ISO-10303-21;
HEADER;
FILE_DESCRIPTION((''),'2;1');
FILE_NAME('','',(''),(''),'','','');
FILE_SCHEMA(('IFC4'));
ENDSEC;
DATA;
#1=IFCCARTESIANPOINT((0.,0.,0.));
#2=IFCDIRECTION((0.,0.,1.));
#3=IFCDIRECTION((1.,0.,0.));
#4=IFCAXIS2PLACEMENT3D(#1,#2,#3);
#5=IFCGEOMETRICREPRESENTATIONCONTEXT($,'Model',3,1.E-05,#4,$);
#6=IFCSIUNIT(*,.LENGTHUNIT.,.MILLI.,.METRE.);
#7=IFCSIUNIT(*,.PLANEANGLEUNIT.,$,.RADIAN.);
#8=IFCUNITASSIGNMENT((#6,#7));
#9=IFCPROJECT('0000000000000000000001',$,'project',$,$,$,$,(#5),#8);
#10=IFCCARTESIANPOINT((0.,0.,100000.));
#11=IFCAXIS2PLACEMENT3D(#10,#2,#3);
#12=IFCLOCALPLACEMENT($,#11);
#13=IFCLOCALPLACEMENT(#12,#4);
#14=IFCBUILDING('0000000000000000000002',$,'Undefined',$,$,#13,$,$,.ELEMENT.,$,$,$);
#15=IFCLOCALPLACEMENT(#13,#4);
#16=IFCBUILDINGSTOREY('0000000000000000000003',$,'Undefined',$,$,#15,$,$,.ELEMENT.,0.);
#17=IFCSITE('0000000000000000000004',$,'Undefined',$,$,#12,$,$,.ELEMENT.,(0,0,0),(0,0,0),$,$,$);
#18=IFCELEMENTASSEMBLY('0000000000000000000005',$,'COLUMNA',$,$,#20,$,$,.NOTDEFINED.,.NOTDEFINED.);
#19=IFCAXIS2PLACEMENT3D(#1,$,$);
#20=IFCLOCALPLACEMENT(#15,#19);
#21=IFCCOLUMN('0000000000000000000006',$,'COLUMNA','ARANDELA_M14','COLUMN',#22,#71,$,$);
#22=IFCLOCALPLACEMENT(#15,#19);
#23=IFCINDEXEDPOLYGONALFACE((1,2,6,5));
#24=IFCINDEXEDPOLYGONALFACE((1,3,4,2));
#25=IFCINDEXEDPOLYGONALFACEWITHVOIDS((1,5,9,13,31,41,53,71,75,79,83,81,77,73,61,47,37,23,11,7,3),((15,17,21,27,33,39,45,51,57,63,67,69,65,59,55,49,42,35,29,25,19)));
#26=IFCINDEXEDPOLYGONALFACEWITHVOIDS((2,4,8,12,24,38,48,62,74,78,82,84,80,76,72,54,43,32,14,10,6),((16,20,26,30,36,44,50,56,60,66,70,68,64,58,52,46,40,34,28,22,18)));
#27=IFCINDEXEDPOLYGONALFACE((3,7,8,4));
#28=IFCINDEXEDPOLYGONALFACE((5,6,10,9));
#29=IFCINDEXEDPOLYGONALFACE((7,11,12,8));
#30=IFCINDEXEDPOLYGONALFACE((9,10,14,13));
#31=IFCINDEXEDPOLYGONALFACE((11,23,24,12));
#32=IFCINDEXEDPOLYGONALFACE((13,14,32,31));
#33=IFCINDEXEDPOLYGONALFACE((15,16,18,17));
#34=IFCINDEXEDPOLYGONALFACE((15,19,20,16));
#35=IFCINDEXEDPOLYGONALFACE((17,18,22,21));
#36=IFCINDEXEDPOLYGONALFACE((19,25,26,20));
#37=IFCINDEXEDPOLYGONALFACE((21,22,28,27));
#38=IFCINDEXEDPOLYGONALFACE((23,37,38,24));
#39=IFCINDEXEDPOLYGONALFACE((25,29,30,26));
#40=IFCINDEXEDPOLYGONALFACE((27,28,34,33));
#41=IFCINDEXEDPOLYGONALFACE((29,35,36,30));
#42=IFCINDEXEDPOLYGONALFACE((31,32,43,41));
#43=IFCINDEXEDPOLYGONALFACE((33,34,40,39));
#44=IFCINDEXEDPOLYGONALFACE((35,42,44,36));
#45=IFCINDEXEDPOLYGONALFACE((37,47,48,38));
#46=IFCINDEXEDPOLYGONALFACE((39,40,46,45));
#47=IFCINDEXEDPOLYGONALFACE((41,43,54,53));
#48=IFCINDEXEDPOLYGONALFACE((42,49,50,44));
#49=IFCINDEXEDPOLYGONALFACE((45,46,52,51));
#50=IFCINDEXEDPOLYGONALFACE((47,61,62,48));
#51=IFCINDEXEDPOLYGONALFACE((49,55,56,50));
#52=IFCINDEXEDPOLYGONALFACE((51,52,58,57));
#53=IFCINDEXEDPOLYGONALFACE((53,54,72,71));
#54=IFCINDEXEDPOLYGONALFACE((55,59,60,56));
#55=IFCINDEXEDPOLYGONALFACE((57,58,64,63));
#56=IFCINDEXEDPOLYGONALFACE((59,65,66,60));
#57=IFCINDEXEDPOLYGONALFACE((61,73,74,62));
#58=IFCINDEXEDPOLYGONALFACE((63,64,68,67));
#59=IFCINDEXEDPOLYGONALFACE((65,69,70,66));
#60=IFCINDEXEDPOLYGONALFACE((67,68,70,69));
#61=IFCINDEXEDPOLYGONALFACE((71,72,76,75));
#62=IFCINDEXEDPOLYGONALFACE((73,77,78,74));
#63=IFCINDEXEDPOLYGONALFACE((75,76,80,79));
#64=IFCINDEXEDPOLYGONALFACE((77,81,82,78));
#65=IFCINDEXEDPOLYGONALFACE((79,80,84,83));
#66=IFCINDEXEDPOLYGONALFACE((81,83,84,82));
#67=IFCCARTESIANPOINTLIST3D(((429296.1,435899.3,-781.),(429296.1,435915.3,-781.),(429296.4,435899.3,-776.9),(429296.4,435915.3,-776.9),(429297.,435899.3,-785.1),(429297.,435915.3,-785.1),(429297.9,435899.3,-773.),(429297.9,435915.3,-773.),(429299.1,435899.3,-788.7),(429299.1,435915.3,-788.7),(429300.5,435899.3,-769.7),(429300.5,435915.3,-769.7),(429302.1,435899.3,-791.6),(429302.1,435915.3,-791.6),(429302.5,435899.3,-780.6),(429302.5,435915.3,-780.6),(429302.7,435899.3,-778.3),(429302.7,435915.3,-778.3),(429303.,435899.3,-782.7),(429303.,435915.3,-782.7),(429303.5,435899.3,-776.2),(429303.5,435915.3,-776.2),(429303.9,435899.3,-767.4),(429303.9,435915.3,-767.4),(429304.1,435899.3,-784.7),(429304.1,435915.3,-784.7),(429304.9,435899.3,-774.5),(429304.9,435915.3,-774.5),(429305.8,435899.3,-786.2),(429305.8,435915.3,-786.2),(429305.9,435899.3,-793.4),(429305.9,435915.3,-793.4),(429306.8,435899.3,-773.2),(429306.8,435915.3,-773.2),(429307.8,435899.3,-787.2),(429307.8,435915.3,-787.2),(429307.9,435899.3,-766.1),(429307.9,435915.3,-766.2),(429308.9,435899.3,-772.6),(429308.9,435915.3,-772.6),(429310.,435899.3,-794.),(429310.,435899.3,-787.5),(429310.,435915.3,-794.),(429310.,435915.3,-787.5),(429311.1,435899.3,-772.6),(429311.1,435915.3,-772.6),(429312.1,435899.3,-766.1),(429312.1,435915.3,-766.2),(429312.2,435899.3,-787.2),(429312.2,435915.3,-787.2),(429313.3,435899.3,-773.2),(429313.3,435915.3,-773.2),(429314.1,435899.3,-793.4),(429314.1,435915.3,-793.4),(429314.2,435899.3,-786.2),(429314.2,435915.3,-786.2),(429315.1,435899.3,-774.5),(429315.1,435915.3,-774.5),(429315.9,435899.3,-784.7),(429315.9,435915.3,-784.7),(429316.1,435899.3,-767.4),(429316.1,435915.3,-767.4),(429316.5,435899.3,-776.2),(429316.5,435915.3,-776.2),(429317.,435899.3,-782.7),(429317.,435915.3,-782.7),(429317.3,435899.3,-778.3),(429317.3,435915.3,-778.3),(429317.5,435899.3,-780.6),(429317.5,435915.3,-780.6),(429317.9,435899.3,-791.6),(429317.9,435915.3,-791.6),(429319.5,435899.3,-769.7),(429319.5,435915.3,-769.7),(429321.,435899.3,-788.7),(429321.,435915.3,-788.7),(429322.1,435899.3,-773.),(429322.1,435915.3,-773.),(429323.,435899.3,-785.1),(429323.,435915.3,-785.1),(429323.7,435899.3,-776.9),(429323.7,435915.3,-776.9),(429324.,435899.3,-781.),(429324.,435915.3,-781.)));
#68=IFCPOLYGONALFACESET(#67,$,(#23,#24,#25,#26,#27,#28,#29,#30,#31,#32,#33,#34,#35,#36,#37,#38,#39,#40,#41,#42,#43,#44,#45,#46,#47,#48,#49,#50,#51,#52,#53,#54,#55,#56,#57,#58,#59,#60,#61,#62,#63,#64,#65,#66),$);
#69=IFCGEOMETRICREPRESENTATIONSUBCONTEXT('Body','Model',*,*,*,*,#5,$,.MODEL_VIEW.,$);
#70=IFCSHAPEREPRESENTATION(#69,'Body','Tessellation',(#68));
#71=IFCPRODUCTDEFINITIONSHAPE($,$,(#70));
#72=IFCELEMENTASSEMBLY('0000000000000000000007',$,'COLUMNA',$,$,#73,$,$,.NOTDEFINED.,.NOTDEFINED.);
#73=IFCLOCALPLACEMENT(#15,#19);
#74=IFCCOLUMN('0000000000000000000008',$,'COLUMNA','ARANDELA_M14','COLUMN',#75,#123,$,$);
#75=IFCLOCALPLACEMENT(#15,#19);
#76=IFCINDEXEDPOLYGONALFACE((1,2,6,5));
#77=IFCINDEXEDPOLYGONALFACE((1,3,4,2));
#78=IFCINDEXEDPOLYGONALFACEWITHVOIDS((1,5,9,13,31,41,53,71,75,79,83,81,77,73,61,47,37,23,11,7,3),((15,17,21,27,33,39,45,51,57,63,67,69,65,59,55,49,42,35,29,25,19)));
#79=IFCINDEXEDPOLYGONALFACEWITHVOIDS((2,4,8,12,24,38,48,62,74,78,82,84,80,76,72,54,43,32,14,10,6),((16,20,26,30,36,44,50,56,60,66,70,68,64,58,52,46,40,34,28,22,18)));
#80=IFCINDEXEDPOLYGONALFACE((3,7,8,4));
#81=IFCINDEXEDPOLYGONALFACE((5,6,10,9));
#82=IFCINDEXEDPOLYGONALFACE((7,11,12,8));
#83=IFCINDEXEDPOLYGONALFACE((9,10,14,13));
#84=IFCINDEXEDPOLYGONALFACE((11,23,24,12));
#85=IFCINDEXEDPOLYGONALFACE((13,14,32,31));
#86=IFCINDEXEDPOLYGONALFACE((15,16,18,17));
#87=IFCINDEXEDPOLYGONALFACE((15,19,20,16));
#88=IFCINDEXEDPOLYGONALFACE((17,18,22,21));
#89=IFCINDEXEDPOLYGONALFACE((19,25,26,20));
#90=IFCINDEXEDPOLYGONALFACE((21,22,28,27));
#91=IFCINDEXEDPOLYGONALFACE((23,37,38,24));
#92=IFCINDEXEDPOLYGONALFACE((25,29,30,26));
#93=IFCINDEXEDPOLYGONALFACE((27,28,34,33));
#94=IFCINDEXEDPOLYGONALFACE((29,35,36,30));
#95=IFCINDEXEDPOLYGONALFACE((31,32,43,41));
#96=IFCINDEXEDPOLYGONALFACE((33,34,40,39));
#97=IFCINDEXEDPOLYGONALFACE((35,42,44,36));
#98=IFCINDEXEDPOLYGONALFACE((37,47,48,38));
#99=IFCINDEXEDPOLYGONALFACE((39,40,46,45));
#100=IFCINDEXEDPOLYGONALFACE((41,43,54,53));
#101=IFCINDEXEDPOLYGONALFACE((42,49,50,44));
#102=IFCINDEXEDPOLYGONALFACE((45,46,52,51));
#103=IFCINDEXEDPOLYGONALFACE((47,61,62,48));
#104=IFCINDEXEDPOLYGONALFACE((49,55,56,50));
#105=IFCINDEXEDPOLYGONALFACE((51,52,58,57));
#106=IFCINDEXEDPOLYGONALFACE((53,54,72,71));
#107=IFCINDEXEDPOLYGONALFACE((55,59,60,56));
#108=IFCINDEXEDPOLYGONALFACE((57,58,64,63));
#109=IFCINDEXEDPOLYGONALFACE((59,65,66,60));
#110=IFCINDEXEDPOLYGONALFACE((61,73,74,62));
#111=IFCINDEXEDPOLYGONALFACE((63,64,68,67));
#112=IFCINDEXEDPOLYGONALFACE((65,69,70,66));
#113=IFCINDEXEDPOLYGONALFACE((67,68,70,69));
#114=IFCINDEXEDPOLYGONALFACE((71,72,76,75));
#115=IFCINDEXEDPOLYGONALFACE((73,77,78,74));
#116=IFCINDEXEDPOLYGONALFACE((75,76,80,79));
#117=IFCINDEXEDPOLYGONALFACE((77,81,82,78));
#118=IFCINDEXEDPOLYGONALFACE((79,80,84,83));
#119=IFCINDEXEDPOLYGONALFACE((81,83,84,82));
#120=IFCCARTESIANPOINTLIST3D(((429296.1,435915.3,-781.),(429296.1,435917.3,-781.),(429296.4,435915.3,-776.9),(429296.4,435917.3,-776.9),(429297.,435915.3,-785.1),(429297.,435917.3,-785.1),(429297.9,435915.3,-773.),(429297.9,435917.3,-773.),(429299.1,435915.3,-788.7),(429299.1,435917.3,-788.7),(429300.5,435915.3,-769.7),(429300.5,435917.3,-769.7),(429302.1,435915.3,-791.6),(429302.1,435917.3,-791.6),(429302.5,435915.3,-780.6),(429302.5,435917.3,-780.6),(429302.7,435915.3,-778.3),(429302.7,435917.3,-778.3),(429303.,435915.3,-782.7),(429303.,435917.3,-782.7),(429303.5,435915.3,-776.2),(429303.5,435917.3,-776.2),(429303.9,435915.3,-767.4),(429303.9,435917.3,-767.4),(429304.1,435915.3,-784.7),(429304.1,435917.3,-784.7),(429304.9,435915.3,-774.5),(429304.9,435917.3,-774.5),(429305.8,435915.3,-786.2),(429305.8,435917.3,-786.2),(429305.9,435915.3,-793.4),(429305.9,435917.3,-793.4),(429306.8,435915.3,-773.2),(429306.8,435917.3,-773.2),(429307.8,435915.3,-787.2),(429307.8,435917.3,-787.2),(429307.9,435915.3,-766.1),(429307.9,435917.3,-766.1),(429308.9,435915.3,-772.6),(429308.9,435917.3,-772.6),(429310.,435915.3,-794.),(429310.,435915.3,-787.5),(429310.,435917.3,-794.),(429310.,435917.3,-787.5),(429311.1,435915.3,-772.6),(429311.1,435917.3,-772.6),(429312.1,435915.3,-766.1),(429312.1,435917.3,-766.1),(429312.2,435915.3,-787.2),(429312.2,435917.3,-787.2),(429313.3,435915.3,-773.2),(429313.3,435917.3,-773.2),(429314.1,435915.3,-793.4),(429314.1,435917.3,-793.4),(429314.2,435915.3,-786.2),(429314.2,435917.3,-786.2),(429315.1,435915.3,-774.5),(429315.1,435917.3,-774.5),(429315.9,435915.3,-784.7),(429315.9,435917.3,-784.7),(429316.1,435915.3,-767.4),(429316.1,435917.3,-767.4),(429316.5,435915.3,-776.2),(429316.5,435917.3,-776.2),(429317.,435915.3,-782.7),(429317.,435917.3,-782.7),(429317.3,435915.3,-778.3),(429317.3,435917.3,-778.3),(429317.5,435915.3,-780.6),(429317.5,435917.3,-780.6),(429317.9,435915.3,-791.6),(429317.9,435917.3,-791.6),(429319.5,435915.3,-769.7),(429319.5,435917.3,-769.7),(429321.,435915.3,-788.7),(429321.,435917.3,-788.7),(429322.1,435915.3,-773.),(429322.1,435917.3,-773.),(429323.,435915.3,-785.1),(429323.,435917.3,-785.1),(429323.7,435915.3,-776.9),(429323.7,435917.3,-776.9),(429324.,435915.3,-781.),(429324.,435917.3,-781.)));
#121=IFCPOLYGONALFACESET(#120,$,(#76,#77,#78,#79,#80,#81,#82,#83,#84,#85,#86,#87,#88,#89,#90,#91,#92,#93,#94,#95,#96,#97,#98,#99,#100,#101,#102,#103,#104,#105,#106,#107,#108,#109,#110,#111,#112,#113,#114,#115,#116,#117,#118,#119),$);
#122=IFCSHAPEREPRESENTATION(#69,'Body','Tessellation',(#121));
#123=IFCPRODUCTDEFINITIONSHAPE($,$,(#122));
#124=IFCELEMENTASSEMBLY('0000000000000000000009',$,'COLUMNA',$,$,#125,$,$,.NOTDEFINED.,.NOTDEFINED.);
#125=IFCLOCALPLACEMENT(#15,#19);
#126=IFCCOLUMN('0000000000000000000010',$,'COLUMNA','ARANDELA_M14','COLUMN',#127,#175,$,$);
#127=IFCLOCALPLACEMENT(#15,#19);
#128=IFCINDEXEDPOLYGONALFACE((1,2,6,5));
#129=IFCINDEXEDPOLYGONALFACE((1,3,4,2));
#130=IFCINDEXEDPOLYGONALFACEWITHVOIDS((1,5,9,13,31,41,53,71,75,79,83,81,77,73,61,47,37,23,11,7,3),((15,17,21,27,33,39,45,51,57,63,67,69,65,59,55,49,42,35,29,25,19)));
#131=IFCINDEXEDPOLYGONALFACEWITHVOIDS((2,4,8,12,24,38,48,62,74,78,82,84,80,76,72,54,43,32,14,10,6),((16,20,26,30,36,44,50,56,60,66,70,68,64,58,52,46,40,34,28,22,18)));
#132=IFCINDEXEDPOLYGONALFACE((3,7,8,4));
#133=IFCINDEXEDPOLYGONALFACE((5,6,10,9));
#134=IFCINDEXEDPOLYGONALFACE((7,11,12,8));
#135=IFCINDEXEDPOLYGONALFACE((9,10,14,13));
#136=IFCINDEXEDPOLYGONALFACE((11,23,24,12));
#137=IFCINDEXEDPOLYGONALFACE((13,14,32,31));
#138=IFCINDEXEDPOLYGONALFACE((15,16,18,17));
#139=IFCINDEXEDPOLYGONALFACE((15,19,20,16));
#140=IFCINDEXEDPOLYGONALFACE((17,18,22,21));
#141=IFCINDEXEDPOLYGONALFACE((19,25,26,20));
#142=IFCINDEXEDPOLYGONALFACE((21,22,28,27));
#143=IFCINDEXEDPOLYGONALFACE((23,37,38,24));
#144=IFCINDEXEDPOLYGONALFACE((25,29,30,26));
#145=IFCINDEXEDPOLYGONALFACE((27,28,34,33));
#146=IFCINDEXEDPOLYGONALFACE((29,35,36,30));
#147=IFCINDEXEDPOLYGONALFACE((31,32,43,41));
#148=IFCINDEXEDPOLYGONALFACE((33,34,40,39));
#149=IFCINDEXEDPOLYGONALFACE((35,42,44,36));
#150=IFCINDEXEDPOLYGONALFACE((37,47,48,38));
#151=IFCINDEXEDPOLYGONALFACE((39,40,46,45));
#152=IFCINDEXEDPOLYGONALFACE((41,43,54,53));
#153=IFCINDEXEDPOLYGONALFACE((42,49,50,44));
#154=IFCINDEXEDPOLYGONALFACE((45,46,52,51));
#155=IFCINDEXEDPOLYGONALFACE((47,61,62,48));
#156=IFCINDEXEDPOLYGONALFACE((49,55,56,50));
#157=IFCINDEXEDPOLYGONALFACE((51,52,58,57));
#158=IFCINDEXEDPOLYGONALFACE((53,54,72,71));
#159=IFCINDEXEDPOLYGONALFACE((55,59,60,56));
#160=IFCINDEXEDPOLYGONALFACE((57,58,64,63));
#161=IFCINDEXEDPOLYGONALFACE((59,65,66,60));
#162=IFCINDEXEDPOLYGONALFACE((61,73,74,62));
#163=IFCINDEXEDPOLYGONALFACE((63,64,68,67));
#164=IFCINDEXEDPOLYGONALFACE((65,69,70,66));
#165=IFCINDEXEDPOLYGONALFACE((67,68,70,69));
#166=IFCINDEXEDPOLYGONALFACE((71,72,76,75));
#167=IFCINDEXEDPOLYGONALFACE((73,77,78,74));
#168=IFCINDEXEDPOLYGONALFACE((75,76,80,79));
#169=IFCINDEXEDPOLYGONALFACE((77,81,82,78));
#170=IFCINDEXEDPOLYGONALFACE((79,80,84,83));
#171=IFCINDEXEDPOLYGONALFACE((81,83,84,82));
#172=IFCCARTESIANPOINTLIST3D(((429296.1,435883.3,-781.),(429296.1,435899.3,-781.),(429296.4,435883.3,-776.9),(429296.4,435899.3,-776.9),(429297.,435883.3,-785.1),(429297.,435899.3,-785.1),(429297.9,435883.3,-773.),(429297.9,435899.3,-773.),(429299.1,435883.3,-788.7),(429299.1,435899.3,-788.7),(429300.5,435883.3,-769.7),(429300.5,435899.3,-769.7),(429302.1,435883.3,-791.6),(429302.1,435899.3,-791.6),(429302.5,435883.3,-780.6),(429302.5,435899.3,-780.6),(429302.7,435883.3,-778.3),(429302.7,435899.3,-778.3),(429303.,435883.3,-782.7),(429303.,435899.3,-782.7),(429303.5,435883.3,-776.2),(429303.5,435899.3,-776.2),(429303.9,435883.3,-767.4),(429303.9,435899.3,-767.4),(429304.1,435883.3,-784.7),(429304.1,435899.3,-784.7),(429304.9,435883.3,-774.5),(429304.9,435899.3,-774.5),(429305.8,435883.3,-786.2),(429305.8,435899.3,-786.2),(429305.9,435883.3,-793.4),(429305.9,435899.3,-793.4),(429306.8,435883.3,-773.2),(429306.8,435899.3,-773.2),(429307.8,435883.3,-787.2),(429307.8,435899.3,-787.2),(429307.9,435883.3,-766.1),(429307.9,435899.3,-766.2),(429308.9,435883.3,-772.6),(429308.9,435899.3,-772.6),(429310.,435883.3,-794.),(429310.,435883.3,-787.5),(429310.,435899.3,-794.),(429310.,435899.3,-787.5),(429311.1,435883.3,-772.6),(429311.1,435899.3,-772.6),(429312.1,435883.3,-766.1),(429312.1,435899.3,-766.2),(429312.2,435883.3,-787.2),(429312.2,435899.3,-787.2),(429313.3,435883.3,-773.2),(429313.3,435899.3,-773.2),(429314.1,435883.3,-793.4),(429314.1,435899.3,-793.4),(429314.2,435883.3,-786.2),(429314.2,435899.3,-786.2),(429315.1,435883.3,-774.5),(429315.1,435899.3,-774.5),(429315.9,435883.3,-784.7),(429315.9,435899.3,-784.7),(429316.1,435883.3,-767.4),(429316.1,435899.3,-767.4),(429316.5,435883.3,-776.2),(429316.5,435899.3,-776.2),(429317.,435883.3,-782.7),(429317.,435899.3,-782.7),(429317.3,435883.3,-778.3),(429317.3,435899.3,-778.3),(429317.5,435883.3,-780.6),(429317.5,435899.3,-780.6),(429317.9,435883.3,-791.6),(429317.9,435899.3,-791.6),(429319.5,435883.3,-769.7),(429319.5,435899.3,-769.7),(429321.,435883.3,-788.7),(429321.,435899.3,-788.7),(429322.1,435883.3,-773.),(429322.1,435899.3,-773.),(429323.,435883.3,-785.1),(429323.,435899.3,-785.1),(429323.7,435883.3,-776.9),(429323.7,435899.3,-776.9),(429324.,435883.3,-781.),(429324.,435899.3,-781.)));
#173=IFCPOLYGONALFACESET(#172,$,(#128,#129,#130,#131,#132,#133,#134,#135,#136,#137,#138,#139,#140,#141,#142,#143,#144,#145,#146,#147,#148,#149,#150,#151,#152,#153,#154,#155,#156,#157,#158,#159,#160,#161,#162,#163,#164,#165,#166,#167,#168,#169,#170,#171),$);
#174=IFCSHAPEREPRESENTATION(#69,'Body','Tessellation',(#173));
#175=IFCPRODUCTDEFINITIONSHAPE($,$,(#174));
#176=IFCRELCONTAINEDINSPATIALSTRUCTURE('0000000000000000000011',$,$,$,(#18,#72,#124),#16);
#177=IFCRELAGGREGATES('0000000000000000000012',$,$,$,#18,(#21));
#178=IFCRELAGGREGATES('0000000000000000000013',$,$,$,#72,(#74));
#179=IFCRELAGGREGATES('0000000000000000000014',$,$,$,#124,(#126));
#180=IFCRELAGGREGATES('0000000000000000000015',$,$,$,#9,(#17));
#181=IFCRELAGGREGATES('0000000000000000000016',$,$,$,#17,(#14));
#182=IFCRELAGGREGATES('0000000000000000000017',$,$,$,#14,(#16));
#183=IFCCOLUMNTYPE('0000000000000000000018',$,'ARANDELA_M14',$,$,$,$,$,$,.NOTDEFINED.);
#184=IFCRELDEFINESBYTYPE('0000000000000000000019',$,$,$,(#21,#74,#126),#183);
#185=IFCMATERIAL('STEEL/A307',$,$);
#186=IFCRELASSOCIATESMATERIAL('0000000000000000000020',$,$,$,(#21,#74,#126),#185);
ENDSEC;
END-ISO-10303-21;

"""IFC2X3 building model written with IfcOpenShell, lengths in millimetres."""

from ifc_helpers import new_model, si_unit, frame, origin_with_axes, origin_2d_with_axis, place, context, subcontext, project, spatial, hollow_circle, extrude, material, type_object, element, aggregate, save


model = new_model("IFC2X3")

# Units and contexts
model_context = context("Model", 3, precision=1e-05, world=origin_with_axes())
body_context = subcontext(model_context, "Body", "Model", "MODEL_VIEW")
ifc_project = project(units=[si_unit("LENGTHUNIT", "METRE", prefix="MILLI"), si_unit("PLANEANGLEUNIT", "RADIAN")], contexts=[model_context])

# Site, building, storey
site_placement = place(None, frame((0.0, 0.0, 100000.0), z_axis=(0.0, 0.0, 1.0), x_axis=(1.0, 0.0, 0.0)))
site = spatial("IfcSite", under=ifc_project, at=site_placement, Name="Undefined", CompositionType="ELEMENT", RefLatitude=(0, 0, 0), RefLongitude=(0, 0, 0))
building_placement = place(site_placement, origin_with_axes())
building = spatial("IfcBuilding", under=site, at=building_placement, Name="Undefined", CompositionType="ELEMENT")
storey_placement = place(building_placement, origin_with_axes())
storey = spatial("IfcBuildingStorey", under=building, at=storey_placement, Name="Undefined", CompositionType="ELEMENT", Elevation=0.0)

# Element assemblies, columns
ifc_material_1 = material(Name="STEEL/A307")
column_type = type_object("IfcColumnType", Name="ARANDELA_M14", PredefinedType="NOTDEFINED")
assembly_1_placement = place(storey_placement, origin_with_axes())
assembly_1 = element("IfcElementAssembly", 1, at=assembly_1_placement, inside=storey, Name="COLUMNA", AssemblyPlace="NOTDEFINED", PredefinedType="NOTDEFINED")
column_1_placement = place(assembly_1_placement, frame((429310.0, 435915.3, -780.0), z_axis=(0.0, -1.0, 0.000285), x_axis=(-1.0, 0.0, 0.0)))
column_1 = element("IfcColumn", 2, at=column_1_placement, type_object=column_type, material=ifc_material_1, Name="COLUMNA", Description="ARANDELA_M14", ObjectType="COLUMN", context=body_context, shape_type="SweptSolid", body=[
    extrude(hollow_circle(Radius=14.0, WallThickness=6.5, at=origin_2d_with_axis()), frame((0.0, 0.0, 16.0), z_axis=(0.0, 0.0, -1.0), x_axis=(0.0, 1.0, 0.0)), (0.0, 0.0, 1.0), 16.0),
])
aggregate(assembly_1, [column_1])
assembly_2_placement = place(storey_placement, origin_with_axes())
assembly_2 = element("IfcElementAssembly", 3, at=assembly_2_placement, inside=storey, Name="COLUMNA", AssemblyPlace="NOTDEFINED", PredefinedType="NOTDEFINED")
column_2_placement = place(assembly_2_placement, frame((429310.0, 435917.3, -780.0), z_axis=(0.0, -1.0, 0.000285), x_axis=(-1.0, 0.0, 0.0)))
column_2 = element("IfcColumn", 4, at=column_2_placement, type_object=column_type, material=ifc_material_1, Name="COLUMNA", Description="ARANDELA_M14", ObjectType="COLUMN", context=body_context, shape_type="SweptSolid", body=[
    extrude(hollow_circle(Radius=14.0, WallThickness=6.5, at=origin_2d_with_axis()), frame((0.0, 0.0, 2.0), z_axis=(0.0, 0.0, -1.0), x_axis=(0.0, 1.0, 0.0)), (0.0, 0.0, 1.0), 2.0),
])
aggregate(assembly_2, [column_2])
assembly_3_placement = place(storey_placement, origin_with_axes())
assembly_3 = element("IfcElementAssembly", 5, at=assembly_3_placement, inside=storey, Name="COLUMNA", AssemblyPlace="NOTDEFINED", PredefinedType="NOTDEFINED")
column_3_placement = place(assembly_3_placement, frame((429310.0, 435899.3, -780.0), z_axis=(0.0, -1.0, 0.000285), x_axis=(-1.0, 0.0, 0.0)))
column_3 = element("IfcColumn", 6, at=column_3_placement, type_object=column_type, material=ifc_material_1, Name="COLUMNA", Description="ARANDELA_M14", ObjectType="COLUMN", context=body_context, shape_type="SweptSolid", body=[
    extrude(hollow_circle(Radius=14.0, WallThickness=6.5, at=origin_2d_with_axis()), frame((0.0, 0.0, 16.0), z_axis=(0.0, 0.0, -1.0), x_axis=(0.0, 1.0, 0.0)), (0.0, 0.0, 1.0), 16.0),
])
aggregate(assembly_3, [column_3])

save(model, "model.ifc")
